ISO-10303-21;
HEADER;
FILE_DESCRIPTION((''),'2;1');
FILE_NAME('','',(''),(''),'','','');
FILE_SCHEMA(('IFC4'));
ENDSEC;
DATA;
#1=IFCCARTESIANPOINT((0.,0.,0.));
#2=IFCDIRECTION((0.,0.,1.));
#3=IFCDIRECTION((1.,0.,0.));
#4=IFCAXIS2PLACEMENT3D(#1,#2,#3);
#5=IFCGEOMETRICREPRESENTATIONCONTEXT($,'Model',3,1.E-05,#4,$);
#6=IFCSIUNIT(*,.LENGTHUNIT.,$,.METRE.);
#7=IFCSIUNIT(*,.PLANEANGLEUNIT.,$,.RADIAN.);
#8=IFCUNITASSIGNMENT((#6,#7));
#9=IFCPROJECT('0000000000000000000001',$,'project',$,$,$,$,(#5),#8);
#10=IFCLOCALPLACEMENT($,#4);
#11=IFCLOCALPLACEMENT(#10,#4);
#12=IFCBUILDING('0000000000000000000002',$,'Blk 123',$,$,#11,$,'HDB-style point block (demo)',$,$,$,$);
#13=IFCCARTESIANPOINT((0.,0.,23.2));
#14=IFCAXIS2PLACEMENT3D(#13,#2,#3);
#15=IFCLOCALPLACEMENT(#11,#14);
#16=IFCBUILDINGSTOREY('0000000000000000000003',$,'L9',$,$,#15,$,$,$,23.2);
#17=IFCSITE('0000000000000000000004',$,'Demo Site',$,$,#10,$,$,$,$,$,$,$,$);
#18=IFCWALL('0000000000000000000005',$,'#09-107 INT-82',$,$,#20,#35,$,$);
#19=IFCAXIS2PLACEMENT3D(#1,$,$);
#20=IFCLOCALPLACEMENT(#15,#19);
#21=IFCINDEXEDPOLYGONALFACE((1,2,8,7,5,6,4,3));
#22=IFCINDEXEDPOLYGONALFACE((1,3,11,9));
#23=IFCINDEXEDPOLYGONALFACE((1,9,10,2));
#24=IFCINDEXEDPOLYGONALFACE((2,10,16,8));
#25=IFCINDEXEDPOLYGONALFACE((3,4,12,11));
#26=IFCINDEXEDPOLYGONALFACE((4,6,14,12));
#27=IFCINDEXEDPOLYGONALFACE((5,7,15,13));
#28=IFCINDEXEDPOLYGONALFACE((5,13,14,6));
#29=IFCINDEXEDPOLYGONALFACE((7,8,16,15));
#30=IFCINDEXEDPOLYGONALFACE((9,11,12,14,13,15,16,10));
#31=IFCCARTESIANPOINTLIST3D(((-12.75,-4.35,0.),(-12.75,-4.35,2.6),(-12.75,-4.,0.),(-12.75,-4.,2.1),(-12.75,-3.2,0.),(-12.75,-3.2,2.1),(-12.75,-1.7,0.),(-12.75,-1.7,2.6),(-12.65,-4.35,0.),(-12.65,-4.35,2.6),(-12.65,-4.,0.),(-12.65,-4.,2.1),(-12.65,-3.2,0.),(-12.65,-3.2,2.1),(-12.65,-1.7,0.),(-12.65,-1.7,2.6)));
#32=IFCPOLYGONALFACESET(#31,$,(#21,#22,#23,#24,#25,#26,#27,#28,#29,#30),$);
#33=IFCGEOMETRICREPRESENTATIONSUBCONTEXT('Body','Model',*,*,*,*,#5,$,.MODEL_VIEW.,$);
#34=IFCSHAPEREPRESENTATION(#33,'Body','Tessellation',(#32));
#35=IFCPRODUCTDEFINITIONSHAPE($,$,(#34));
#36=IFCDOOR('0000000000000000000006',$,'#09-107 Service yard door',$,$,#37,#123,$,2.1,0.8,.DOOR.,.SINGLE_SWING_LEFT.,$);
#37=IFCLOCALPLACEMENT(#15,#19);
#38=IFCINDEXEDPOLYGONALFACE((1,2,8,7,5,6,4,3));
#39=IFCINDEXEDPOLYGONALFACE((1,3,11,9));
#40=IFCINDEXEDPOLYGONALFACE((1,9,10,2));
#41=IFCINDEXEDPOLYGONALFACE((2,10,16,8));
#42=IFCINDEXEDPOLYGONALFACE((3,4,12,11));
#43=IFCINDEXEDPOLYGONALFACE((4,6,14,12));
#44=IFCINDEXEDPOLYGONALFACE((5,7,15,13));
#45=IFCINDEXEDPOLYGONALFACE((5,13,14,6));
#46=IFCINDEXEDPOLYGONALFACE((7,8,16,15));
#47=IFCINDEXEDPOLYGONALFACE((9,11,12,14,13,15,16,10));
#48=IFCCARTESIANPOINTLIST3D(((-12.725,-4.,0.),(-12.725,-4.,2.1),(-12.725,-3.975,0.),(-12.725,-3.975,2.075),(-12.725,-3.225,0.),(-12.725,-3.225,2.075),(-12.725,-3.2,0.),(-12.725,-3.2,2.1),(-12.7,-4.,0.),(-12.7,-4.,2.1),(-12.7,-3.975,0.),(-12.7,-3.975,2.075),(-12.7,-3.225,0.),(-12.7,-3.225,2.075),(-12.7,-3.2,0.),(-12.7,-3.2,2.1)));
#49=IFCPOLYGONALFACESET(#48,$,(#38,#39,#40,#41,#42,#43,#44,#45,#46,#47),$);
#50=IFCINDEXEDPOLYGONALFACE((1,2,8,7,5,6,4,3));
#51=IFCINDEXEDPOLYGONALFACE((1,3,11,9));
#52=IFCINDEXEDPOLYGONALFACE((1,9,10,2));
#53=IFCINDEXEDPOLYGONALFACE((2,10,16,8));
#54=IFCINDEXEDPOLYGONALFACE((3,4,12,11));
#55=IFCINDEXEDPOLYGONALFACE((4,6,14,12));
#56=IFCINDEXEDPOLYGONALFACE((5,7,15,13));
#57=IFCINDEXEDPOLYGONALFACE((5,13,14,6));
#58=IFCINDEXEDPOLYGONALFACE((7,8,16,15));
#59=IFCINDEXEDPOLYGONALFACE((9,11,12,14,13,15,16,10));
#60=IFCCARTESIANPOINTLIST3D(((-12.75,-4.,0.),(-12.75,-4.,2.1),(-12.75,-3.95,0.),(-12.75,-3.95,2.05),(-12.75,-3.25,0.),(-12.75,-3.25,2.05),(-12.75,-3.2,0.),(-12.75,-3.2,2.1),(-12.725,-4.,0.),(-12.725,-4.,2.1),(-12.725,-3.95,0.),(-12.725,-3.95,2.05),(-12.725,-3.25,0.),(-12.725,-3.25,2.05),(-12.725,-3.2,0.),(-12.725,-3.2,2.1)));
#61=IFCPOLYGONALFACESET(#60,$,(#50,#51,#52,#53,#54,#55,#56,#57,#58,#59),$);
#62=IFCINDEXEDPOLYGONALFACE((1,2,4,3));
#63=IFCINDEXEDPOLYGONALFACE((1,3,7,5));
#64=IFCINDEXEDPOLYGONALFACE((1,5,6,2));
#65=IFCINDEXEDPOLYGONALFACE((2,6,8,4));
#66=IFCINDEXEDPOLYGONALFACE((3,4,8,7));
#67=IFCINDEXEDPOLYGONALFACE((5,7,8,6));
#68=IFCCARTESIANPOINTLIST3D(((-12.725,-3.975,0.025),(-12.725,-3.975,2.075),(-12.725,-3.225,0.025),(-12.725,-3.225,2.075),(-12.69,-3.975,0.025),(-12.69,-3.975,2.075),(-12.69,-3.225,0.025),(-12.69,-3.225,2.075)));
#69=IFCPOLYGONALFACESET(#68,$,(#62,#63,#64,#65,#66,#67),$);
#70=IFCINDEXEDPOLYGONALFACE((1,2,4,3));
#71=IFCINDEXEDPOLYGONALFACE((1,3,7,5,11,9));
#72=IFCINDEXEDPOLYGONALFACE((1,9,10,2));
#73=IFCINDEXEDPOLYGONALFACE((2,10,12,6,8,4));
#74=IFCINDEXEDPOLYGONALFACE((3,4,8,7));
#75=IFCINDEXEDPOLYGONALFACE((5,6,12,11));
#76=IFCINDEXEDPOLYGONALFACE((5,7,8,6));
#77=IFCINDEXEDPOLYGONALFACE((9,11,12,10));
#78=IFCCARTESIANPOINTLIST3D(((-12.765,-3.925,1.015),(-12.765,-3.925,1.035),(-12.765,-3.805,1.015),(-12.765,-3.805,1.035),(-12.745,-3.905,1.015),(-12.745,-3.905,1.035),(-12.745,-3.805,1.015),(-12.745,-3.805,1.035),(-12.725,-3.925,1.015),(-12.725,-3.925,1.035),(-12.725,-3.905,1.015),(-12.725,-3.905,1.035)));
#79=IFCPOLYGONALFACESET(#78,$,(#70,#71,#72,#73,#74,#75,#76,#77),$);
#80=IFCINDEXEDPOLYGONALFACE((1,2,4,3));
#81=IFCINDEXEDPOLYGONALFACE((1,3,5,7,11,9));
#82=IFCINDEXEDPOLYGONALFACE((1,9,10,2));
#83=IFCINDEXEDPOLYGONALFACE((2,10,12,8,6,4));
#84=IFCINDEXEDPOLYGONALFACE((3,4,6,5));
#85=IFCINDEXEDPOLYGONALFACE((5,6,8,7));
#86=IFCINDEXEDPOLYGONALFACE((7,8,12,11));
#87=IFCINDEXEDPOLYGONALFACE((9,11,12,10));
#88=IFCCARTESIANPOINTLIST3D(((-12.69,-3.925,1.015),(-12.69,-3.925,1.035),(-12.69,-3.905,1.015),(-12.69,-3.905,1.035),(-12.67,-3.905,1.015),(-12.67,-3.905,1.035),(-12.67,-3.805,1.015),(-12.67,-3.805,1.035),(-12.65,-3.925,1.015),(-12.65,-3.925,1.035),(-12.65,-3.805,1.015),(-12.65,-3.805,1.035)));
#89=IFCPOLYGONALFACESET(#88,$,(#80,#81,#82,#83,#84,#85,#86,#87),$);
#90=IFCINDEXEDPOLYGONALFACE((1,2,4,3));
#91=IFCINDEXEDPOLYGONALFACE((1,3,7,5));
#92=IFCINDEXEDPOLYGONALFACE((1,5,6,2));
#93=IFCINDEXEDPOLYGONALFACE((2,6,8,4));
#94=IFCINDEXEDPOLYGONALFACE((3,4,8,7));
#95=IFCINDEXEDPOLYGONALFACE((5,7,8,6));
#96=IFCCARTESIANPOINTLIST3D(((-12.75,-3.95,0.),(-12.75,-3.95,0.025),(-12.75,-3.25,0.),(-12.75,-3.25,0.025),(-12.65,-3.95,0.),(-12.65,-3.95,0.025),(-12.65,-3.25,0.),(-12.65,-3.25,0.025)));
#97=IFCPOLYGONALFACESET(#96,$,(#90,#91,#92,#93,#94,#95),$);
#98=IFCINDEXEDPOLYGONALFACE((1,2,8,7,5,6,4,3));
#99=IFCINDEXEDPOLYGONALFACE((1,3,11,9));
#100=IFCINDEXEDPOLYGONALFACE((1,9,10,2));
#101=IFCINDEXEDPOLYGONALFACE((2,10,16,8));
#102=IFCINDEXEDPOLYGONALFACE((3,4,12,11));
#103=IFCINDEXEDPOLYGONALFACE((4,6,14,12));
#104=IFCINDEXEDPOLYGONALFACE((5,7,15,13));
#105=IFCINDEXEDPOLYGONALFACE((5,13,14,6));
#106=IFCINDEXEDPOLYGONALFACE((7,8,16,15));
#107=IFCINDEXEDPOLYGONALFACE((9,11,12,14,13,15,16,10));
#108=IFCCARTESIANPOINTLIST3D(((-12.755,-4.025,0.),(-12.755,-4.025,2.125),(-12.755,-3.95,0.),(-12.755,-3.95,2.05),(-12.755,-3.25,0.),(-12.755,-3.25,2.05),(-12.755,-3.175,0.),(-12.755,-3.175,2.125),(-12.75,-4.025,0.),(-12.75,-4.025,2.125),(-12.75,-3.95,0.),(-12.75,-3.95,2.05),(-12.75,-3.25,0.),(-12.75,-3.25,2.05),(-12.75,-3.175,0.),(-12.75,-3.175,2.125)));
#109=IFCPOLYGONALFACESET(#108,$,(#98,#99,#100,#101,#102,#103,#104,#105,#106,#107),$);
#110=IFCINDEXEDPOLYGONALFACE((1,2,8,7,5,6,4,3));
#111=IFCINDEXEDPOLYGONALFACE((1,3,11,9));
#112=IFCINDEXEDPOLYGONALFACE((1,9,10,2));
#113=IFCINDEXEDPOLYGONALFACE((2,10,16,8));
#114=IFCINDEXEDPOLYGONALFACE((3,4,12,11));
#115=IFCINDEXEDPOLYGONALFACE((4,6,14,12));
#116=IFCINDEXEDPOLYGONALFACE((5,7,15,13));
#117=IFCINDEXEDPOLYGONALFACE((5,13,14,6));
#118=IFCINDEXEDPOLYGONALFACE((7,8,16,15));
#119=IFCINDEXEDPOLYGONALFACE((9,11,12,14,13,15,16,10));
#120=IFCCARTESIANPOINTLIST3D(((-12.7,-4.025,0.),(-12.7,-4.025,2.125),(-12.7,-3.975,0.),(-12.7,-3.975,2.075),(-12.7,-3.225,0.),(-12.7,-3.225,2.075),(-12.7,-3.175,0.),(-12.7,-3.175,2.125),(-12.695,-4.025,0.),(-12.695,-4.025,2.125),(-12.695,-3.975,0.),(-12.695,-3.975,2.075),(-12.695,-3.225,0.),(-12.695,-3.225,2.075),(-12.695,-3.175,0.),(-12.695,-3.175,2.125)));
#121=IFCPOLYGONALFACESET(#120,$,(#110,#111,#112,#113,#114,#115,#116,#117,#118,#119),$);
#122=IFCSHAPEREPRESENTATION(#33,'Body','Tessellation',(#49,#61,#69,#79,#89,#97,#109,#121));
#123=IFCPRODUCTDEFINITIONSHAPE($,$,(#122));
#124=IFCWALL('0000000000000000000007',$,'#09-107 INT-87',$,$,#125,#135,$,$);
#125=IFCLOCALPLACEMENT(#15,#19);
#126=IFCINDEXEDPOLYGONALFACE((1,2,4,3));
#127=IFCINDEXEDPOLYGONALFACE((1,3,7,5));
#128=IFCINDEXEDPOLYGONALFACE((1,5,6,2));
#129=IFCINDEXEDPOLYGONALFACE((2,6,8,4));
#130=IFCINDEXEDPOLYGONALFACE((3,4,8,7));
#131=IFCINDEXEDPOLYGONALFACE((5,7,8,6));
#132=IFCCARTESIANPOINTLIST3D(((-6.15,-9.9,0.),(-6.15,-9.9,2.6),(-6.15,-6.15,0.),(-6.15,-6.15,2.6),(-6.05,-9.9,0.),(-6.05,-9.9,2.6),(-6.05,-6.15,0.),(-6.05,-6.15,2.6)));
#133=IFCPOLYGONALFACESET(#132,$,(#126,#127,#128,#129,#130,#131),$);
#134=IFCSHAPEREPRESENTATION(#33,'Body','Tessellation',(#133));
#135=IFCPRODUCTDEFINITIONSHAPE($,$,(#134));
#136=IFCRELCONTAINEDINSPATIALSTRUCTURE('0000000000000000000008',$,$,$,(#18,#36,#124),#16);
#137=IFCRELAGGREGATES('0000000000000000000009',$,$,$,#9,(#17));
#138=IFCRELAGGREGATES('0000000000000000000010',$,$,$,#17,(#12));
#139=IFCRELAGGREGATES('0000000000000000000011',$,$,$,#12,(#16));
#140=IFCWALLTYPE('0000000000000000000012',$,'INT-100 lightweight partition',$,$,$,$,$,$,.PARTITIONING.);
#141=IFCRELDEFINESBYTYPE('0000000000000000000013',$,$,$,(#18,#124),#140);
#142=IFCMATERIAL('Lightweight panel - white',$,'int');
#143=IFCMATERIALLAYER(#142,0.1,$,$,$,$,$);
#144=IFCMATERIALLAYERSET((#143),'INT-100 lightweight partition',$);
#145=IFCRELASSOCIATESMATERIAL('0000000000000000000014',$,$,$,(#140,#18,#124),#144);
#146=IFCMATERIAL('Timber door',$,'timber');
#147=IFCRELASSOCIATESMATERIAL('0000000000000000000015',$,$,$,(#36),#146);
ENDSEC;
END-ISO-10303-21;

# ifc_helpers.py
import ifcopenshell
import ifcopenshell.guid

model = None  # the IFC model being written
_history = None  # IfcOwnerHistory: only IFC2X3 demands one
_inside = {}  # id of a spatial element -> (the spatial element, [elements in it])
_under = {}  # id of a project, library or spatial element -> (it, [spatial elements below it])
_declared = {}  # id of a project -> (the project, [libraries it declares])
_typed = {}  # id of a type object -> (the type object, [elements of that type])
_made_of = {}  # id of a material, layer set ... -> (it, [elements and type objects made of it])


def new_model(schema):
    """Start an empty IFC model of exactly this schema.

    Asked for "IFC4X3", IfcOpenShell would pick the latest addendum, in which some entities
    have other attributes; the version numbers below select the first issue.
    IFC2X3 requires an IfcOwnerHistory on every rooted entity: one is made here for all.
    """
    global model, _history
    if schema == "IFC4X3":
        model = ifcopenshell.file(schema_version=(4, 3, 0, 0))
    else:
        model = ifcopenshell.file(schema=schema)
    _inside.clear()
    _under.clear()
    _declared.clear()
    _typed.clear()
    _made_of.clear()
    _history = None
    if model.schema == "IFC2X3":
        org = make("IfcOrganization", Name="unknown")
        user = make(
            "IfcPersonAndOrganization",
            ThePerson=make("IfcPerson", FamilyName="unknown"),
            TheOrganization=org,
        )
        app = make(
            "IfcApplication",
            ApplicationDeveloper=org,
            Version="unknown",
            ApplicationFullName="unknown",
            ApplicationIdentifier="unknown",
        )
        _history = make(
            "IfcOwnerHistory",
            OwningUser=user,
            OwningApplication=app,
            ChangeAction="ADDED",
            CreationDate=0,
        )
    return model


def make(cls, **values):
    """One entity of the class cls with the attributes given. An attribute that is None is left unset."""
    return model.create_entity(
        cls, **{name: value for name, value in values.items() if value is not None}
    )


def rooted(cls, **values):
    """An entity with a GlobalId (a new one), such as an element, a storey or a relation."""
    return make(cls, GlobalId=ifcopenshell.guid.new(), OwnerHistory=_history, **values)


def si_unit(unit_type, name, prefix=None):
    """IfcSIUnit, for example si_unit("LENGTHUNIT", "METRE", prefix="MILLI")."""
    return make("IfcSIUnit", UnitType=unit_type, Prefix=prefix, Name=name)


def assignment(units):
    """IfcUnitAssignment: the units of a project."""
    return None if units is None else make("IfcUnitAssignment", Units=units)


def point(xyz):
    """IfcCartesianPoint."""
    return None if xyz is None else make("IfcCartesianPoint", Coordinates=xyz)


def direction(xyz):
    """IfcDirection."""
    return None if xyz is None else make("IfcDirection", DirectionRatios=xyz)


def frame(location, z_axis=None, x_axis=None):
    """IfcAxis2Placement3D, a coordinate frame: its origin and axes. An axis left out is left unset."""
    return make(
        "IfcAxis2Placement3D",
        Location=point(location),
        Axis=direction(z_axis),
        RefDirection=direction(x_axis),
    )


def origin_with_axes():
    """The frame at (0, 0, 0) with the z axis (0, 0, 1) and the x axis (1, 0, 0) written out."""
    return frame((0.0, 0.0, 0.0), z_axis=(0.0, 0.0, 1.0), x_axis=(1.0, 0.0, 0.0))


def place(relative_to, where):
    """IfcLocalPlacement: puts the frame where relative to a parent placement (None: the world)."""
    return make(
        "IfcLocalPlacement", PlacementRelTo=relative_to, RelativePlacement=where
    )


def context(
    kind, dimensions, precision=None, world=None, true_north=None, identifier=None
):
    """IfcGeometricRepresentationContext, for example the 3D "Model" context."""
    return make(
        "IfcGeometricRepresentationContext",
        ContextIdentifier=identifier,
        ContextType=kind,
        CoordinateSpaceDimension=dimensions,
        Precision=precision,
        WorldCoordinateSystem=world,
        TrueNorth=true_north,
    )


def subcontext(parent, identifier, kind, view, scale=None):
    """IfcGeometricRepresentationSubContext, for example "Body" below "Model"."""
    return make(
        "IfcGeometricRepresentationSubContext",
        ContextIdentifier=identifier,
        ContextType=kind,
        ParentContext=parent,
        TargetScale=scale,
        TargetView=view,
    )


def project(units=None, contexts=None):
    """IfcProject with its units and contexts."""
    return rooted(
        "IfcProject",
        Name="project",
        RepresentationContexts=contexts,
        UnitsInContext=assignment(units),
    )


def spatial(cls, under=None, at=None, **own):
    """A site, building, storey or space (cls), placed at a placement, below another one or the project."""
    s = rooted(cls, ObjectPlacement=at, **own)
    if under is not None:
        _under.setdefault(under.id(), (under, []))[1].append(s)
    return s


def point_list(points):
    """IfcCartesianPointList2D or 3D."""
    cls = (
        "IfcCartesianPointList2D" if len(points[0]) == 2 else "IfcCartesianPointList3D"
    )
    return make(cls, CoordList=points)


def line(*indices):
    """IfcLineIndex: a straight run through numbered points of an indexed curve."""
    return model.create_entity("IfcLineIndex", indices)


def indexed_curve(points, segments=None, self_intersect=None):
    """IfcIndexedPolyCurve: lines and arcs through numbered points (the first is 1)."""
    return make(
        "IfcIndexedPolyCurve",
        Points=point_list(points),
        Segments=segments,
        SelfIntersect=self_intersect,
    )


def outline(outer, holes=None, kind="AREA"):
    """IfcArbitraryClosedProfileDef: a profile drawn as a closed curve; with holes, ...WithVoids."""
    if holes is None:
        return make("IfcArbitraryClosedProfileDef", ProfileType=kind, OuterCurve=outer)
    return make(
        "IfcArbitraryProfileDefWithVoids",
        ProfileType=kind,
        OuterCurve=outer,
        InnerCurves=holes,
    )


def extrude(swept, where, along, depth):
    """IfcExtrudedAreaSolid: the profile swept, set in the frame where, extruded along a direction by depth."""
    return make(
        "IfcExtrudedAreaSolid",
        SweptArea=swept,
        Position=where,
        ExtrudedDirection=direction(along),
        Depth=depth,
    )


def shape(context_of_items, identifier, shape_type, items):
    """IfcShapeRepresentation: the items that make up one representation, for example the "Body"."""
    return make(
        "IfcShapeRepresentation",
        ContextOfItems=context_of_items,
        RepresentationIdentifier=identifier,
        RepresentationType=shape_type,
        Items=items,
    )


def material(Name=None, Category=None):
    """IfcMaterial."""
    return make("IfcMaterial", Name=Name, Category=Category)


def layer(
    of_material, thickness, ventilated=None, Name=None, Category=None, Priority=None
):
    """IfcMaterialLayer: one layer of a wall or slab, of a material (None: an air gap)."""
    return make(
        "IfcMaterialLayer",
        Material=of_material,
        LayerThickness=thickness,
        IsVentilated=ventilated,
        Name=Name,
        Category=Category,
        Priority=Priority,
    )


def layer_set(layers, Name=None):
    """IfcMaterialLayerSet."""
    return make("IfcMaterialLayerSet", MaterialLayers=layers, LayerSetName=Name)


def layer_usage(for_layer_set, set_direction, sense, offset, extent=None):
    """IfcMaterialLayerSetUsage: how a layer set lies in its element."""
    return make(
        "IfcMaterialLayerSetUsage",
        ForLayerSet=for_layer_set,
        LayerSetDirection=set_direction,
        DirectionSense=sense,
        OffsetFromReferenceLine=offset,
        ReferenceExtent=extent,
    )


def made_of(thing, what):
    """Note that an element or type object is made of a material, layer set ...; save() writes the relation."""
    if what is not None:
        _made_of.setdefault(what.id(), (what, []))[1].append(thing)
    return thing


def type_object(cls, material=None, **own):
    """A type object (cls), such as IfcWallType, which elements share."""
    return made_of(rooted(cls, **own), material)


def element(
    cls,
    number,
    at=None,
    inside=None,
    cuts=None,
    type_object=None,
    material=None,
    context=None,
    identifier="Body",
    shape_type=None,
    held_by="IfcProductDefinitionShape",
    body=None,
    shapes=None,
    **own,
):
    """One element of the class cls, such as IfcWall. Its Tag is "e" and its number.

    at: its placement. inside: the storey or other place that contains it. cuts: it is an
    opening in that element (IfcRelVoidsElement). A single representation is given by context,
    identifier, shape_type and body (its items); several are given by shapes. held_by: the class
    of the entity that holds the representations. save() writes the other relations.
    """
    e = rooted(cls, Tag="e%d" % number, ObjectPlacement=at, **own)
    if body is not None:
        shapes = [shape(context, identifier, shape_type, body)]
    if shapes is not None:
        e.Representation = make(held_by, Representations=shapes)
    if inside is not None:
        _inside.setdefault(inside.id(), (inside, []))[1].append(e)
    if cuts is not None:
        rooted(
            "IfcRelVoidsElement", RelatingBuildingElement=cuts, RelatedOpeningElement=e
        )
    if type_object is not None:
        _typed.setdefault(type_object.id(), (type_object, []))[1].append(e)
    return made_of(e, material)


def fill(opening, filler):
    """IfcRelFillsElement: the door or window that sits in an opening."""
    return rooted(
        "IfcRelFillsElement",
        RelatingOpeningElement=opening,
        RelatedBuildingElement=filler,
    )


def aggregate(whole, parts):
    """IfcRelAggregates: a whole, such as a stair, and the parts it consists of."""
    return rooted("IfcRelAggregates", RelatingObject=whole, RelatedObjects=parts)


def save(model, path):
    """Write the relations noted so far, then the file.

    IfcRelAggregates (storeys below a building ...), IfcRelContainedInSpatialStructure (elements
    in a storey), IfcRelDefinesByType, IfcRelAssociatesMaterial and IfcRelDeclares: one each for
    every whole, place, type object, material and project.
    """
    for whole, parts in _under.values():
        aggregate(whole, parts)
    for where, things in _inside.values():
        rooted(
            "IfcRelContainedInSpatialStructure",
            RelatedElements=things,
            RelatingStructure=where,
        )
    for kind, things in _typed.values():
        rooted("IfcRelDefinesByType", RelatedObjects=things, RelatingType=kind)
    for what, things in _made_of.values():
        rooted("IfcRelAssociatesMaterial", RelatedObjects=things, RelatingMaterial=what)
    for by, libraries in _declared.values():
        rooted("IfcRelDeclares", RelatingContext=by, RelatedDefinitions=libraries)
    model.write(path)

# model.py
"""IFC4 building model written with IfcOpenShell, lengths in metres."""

from ifc_helpers import new_model, si_unit, frame, origin_with_axes, place, context, subcontext, project, spatial, line, indexed_curve, outline, extrude, material, layer, layer_set, layer_usage, type_object, element, fill, save


model = new_model("IFC4")

# Units and contexts
model_context = context("Model", 3, precision=1e-05, world=origin_with_axes())
body_context = subcontext(model_context, "Body", "Model", "MODEL_VIEW")
ifc_project = project(units=[si_unit("LENGTHUNIT", "METRE"), si_unit("PLANEANGLEUNIT", "RADIAN")], contexts=[model_context])

# Site, building, storey
site_placement = place(None, origin_with_axes())
site = spatial("IfcSite", under=ifc_project, at=site_placement, Name="Demo Site")
building_placement = place(site_placement, origin_with_axes())
building = spatial("IfcBuilding", under=site, at=building_placement, Name="Blk 123", LongName="HDB-style point block (demo)")
storey_placement = place(building_placement, frame((0.0, 0.0, 23.2), z_axis=(0.0, 0.0, 1.0), x_axis=(1.0, 0.0, 0.0)))
storey = spatial("IfcBuildingStorey", under=building, at=storey_placement, Name="L9", Elevation=23.2)

# Shared definitions
ifc_material_1 = material(Name="Lightweight panel - white", Category="int")
ifc_layer_1 = layer(ifc_material_1, 0.1)
ifc_layer_set_1 = layer_set([ifc_layer_1], Name="INT-100 lightweight partition")
ifc_layer_usage_1 = layer_usage(ifc_layer_set_1, "AXIS2", "POSITIVE", -0.05)
wall_type_1 = type_object("IfcWallType", Name="INT-100 lightweight partition", PredefinedType="PARTITIONING", material=ifc_layer_set_1)

# Wall, opening, door
ifc_material_2 = material(Name="Timber door", Category="timber")
wall_1_placement = place(storey_placement, frame((-12.7, -1.7, 0.0), z_axis=(0.0, 0.0, 1.0), x_axis=(0.0, -1.0, 0.0)))
wall_1 = element("IfcWall", 1, at=wall_1_placement, inside=storey, type_object=wall_type_1, material=ifc_layer_usage_1, Name="#09-107 INT-82", context=body_context, shape_type="SweptSolid", body=[
    extrude(outline(indexed_curve([(0.0, 0.0), (0.0, 0.1), (2.65, 0.1), (2.65, 0.0), (0.0, 0.0)], self_intersect=False)), frame((0.0, -0.05, 0.0), z_axis=(0.0, 0.0, 1.0), x_axis=(1.0, 0.0, 0.0)), (0.0, 0.0, 1.0), 2.6),
])
opening_1_placement = place(wall_1_placement, frame((1.5, -0.15, 0.0), z_axis=(0.0, 0.0, 1.0), x_axis=(1.0, 0.0, 0.0)))
opening_1 = element("IfcOpeningElement", 2, at=opening_1_placement, cuts=wall_1, context=body_context, shape_type="SweptSolid", body=[
    extrude(outline(indexed_curve([(0.0, 0.0), (0.0, 0.3), (0.8, 0.3), (0.8, 0.0), (0.0, 0.0)], self_intersect=False)), origin_with_axes(), (0.0, 0.0, 1.0), 2.1),
])
door_1_placement = place(opening_1_placement, frame((0.0, 0.1, 0.0), z_axis=(0.0, 0.0, 1.0), x_axis=(1.0, 0.0, 0.0)))
door_1 = element("IfcDoor", 3, at=door_1_placement, inside=storey, material=ifc_material_2, Name="#09-107 Service yard door", OperationType="SINGLE_SWING_LEFT", OverallHeight=2.1, OverallWidth=0.8, PredefinedType="DOOR", context=body_context, shape_type="SweptSolid", body=[
    extrude(outline(indexed_curve([(0.0, 0.0), (0.0, 2.1), (0.8, 2.1), (0.8, 0.0), (0.775, 0.0), (0.775, 2.075), (0.025, 2.075), (0.025, 0.0)], segments=[line(1, 2, 3, 4, 5, 6, 7, 8, 1)])), frame((0.0, 0.025, 0.0), z_axis=(0.0, -1.0, 0.0), x_axis=(1.0, 0.0, 0.0)), (0.0, 0.0, -1.0), 0.025),
    extrude(outline(indexed_curve([(0.0, 0.0), (0.0, 2.1), (0.8, 2.1), (0.8, 0.0), (0.75, 0.0), (0.75, 2.05), (0.05, 2.05), (0.05, 0.0)], segments=[line(1, 2, 3, 4, 5, 6, 7, 8, 1)])), frame((0.0, 0.0, 0.0), z_axis=(0.0, -1.0, 0.0), x_axis=(1.0, 0.0, 0.0)), (0.0, 0.0, -1.0), 0.025),
    extrude(outline(indexed_curve([(0.0, 0.0), (0.75, 0.0), (0.75, 0.035), (0.0, 0.035)], segments=[line(1, 2, 3, 4, 1)])), frame((0.025, 0.025, 0.025), z_axis=(0.0, 0.0, 1.0), x_axis=(1.0, 0.0, 0.0)), (0.0, 0.0, 1.0), 2.05),
    extrude(outline(indexed_curve([(0.0, 0.0), (0.0, -0.04), (-0.12, -0.04), (-0.12, -0.02), (-0.02, -0.02), (-0.02, 0.0)], segments=[line(1, 2, 3, 4, 5, 6, 1)])), frame((0.725, 0.025, 1.015), z_axis=(0.0, 0.0, 1.0), x_axis=(1.0, 0.0, 0.0)), (0.0, 0.0, 1.0), 0.02),
    extrude(outline(indexed_curve([(0.0, 0.0), (0.0, 0.04), (-0.12, 0.04), (-0.12, 0.02), (-0.02, 0.02), (-0.02, 0.0)], segments=[line(1, 2, 3, 4, 5, 6, 1)])), frame((0.725, 0.06, 1.015), z_axis=(0.0, 0.0, 1.0), x_axis=(1.0, 0.0, 0.0)), (0.0, 0.0, 1.0), 0.02),
    extrude(outline(indexed_curve([(0.0, 0.0), (0.7, 0.0), (0.7, 0.1), (0.0, 0.1)], segments=[line(1, 2, 3, 4, 1)])), frame((0.05, 0.0, 0.0), z_axis=(0.0, 0.0, 1.0), x_axis=(1.0, 0.0, 0.0)), (0.0, 0.0, 1.0), 0.025),
    extrude(outline(indexed_curve([(0.0, 0.0), (0.0, 2.125), (0.85, 2.125), (0.85, 0.0), (0.775, 0.0), (0.775, 2.05), (0.075, 2.05), (0.075, 0.0)], segments=[line(1, 2, 3, 4, 5, 6, 7, 8, 1)])), frame((-0.025, -0.005, 0.0), z_axis=(0.0, -1.0, 0.0), x_axis=(1.0, 0.0, 0.0)), (0.0, 0.0, -1.0), 0.005),
    extrude(outline(indexed_curve([(0.0, 0.0), (0.0, 2.125), (0.85, 2.125), (0.85, 0.0), (0.8, 0.0), (0.8, 2.075), (0.05, 2.075), (0.05, 0.0)], segments=[line(1, 2, 3, 4, 5, 6, 7, 8, 1)])), frame((-0.025, 0.05, 0.0), z_axis=(0.0, -1.0, 0.0), x_axis=(1.0, 0.0, 0.0)), (0.0, 0.0, -1.0), 0.005),
])
fill(opening_1, door_1)

# Wall
wall_2_placement = place(storey_placement, frame((-6.1, -6.15, 0.0), z_axis=(0.0, 0.0, 1.0), x_axis=(0.0, -1.0, 0.0)))
element("IfcWall", 4, at=wall_2_placement, inside=storey, type_object=wall_type_1, material=ifc_layer_usage_1, Name="#09-107 INT-87", context=body_context, shape_type="SweptSolid", body=[
    extrude(outline(indexed_curve([(0.0, 0.0), (0.0, 0.1), (3.75, 0.1), (3.75, 0.0), (0.0, 0.0)], self_intersect=False)), frame((0.0, -0.05, 0.0), z_axis=(0.0, 0.0, 1.0), x_axis=(1.0, 0.0, 0.0)), (0.0, 0.0, 1.0), 2.6),
])

save(model, "model.ifc")
